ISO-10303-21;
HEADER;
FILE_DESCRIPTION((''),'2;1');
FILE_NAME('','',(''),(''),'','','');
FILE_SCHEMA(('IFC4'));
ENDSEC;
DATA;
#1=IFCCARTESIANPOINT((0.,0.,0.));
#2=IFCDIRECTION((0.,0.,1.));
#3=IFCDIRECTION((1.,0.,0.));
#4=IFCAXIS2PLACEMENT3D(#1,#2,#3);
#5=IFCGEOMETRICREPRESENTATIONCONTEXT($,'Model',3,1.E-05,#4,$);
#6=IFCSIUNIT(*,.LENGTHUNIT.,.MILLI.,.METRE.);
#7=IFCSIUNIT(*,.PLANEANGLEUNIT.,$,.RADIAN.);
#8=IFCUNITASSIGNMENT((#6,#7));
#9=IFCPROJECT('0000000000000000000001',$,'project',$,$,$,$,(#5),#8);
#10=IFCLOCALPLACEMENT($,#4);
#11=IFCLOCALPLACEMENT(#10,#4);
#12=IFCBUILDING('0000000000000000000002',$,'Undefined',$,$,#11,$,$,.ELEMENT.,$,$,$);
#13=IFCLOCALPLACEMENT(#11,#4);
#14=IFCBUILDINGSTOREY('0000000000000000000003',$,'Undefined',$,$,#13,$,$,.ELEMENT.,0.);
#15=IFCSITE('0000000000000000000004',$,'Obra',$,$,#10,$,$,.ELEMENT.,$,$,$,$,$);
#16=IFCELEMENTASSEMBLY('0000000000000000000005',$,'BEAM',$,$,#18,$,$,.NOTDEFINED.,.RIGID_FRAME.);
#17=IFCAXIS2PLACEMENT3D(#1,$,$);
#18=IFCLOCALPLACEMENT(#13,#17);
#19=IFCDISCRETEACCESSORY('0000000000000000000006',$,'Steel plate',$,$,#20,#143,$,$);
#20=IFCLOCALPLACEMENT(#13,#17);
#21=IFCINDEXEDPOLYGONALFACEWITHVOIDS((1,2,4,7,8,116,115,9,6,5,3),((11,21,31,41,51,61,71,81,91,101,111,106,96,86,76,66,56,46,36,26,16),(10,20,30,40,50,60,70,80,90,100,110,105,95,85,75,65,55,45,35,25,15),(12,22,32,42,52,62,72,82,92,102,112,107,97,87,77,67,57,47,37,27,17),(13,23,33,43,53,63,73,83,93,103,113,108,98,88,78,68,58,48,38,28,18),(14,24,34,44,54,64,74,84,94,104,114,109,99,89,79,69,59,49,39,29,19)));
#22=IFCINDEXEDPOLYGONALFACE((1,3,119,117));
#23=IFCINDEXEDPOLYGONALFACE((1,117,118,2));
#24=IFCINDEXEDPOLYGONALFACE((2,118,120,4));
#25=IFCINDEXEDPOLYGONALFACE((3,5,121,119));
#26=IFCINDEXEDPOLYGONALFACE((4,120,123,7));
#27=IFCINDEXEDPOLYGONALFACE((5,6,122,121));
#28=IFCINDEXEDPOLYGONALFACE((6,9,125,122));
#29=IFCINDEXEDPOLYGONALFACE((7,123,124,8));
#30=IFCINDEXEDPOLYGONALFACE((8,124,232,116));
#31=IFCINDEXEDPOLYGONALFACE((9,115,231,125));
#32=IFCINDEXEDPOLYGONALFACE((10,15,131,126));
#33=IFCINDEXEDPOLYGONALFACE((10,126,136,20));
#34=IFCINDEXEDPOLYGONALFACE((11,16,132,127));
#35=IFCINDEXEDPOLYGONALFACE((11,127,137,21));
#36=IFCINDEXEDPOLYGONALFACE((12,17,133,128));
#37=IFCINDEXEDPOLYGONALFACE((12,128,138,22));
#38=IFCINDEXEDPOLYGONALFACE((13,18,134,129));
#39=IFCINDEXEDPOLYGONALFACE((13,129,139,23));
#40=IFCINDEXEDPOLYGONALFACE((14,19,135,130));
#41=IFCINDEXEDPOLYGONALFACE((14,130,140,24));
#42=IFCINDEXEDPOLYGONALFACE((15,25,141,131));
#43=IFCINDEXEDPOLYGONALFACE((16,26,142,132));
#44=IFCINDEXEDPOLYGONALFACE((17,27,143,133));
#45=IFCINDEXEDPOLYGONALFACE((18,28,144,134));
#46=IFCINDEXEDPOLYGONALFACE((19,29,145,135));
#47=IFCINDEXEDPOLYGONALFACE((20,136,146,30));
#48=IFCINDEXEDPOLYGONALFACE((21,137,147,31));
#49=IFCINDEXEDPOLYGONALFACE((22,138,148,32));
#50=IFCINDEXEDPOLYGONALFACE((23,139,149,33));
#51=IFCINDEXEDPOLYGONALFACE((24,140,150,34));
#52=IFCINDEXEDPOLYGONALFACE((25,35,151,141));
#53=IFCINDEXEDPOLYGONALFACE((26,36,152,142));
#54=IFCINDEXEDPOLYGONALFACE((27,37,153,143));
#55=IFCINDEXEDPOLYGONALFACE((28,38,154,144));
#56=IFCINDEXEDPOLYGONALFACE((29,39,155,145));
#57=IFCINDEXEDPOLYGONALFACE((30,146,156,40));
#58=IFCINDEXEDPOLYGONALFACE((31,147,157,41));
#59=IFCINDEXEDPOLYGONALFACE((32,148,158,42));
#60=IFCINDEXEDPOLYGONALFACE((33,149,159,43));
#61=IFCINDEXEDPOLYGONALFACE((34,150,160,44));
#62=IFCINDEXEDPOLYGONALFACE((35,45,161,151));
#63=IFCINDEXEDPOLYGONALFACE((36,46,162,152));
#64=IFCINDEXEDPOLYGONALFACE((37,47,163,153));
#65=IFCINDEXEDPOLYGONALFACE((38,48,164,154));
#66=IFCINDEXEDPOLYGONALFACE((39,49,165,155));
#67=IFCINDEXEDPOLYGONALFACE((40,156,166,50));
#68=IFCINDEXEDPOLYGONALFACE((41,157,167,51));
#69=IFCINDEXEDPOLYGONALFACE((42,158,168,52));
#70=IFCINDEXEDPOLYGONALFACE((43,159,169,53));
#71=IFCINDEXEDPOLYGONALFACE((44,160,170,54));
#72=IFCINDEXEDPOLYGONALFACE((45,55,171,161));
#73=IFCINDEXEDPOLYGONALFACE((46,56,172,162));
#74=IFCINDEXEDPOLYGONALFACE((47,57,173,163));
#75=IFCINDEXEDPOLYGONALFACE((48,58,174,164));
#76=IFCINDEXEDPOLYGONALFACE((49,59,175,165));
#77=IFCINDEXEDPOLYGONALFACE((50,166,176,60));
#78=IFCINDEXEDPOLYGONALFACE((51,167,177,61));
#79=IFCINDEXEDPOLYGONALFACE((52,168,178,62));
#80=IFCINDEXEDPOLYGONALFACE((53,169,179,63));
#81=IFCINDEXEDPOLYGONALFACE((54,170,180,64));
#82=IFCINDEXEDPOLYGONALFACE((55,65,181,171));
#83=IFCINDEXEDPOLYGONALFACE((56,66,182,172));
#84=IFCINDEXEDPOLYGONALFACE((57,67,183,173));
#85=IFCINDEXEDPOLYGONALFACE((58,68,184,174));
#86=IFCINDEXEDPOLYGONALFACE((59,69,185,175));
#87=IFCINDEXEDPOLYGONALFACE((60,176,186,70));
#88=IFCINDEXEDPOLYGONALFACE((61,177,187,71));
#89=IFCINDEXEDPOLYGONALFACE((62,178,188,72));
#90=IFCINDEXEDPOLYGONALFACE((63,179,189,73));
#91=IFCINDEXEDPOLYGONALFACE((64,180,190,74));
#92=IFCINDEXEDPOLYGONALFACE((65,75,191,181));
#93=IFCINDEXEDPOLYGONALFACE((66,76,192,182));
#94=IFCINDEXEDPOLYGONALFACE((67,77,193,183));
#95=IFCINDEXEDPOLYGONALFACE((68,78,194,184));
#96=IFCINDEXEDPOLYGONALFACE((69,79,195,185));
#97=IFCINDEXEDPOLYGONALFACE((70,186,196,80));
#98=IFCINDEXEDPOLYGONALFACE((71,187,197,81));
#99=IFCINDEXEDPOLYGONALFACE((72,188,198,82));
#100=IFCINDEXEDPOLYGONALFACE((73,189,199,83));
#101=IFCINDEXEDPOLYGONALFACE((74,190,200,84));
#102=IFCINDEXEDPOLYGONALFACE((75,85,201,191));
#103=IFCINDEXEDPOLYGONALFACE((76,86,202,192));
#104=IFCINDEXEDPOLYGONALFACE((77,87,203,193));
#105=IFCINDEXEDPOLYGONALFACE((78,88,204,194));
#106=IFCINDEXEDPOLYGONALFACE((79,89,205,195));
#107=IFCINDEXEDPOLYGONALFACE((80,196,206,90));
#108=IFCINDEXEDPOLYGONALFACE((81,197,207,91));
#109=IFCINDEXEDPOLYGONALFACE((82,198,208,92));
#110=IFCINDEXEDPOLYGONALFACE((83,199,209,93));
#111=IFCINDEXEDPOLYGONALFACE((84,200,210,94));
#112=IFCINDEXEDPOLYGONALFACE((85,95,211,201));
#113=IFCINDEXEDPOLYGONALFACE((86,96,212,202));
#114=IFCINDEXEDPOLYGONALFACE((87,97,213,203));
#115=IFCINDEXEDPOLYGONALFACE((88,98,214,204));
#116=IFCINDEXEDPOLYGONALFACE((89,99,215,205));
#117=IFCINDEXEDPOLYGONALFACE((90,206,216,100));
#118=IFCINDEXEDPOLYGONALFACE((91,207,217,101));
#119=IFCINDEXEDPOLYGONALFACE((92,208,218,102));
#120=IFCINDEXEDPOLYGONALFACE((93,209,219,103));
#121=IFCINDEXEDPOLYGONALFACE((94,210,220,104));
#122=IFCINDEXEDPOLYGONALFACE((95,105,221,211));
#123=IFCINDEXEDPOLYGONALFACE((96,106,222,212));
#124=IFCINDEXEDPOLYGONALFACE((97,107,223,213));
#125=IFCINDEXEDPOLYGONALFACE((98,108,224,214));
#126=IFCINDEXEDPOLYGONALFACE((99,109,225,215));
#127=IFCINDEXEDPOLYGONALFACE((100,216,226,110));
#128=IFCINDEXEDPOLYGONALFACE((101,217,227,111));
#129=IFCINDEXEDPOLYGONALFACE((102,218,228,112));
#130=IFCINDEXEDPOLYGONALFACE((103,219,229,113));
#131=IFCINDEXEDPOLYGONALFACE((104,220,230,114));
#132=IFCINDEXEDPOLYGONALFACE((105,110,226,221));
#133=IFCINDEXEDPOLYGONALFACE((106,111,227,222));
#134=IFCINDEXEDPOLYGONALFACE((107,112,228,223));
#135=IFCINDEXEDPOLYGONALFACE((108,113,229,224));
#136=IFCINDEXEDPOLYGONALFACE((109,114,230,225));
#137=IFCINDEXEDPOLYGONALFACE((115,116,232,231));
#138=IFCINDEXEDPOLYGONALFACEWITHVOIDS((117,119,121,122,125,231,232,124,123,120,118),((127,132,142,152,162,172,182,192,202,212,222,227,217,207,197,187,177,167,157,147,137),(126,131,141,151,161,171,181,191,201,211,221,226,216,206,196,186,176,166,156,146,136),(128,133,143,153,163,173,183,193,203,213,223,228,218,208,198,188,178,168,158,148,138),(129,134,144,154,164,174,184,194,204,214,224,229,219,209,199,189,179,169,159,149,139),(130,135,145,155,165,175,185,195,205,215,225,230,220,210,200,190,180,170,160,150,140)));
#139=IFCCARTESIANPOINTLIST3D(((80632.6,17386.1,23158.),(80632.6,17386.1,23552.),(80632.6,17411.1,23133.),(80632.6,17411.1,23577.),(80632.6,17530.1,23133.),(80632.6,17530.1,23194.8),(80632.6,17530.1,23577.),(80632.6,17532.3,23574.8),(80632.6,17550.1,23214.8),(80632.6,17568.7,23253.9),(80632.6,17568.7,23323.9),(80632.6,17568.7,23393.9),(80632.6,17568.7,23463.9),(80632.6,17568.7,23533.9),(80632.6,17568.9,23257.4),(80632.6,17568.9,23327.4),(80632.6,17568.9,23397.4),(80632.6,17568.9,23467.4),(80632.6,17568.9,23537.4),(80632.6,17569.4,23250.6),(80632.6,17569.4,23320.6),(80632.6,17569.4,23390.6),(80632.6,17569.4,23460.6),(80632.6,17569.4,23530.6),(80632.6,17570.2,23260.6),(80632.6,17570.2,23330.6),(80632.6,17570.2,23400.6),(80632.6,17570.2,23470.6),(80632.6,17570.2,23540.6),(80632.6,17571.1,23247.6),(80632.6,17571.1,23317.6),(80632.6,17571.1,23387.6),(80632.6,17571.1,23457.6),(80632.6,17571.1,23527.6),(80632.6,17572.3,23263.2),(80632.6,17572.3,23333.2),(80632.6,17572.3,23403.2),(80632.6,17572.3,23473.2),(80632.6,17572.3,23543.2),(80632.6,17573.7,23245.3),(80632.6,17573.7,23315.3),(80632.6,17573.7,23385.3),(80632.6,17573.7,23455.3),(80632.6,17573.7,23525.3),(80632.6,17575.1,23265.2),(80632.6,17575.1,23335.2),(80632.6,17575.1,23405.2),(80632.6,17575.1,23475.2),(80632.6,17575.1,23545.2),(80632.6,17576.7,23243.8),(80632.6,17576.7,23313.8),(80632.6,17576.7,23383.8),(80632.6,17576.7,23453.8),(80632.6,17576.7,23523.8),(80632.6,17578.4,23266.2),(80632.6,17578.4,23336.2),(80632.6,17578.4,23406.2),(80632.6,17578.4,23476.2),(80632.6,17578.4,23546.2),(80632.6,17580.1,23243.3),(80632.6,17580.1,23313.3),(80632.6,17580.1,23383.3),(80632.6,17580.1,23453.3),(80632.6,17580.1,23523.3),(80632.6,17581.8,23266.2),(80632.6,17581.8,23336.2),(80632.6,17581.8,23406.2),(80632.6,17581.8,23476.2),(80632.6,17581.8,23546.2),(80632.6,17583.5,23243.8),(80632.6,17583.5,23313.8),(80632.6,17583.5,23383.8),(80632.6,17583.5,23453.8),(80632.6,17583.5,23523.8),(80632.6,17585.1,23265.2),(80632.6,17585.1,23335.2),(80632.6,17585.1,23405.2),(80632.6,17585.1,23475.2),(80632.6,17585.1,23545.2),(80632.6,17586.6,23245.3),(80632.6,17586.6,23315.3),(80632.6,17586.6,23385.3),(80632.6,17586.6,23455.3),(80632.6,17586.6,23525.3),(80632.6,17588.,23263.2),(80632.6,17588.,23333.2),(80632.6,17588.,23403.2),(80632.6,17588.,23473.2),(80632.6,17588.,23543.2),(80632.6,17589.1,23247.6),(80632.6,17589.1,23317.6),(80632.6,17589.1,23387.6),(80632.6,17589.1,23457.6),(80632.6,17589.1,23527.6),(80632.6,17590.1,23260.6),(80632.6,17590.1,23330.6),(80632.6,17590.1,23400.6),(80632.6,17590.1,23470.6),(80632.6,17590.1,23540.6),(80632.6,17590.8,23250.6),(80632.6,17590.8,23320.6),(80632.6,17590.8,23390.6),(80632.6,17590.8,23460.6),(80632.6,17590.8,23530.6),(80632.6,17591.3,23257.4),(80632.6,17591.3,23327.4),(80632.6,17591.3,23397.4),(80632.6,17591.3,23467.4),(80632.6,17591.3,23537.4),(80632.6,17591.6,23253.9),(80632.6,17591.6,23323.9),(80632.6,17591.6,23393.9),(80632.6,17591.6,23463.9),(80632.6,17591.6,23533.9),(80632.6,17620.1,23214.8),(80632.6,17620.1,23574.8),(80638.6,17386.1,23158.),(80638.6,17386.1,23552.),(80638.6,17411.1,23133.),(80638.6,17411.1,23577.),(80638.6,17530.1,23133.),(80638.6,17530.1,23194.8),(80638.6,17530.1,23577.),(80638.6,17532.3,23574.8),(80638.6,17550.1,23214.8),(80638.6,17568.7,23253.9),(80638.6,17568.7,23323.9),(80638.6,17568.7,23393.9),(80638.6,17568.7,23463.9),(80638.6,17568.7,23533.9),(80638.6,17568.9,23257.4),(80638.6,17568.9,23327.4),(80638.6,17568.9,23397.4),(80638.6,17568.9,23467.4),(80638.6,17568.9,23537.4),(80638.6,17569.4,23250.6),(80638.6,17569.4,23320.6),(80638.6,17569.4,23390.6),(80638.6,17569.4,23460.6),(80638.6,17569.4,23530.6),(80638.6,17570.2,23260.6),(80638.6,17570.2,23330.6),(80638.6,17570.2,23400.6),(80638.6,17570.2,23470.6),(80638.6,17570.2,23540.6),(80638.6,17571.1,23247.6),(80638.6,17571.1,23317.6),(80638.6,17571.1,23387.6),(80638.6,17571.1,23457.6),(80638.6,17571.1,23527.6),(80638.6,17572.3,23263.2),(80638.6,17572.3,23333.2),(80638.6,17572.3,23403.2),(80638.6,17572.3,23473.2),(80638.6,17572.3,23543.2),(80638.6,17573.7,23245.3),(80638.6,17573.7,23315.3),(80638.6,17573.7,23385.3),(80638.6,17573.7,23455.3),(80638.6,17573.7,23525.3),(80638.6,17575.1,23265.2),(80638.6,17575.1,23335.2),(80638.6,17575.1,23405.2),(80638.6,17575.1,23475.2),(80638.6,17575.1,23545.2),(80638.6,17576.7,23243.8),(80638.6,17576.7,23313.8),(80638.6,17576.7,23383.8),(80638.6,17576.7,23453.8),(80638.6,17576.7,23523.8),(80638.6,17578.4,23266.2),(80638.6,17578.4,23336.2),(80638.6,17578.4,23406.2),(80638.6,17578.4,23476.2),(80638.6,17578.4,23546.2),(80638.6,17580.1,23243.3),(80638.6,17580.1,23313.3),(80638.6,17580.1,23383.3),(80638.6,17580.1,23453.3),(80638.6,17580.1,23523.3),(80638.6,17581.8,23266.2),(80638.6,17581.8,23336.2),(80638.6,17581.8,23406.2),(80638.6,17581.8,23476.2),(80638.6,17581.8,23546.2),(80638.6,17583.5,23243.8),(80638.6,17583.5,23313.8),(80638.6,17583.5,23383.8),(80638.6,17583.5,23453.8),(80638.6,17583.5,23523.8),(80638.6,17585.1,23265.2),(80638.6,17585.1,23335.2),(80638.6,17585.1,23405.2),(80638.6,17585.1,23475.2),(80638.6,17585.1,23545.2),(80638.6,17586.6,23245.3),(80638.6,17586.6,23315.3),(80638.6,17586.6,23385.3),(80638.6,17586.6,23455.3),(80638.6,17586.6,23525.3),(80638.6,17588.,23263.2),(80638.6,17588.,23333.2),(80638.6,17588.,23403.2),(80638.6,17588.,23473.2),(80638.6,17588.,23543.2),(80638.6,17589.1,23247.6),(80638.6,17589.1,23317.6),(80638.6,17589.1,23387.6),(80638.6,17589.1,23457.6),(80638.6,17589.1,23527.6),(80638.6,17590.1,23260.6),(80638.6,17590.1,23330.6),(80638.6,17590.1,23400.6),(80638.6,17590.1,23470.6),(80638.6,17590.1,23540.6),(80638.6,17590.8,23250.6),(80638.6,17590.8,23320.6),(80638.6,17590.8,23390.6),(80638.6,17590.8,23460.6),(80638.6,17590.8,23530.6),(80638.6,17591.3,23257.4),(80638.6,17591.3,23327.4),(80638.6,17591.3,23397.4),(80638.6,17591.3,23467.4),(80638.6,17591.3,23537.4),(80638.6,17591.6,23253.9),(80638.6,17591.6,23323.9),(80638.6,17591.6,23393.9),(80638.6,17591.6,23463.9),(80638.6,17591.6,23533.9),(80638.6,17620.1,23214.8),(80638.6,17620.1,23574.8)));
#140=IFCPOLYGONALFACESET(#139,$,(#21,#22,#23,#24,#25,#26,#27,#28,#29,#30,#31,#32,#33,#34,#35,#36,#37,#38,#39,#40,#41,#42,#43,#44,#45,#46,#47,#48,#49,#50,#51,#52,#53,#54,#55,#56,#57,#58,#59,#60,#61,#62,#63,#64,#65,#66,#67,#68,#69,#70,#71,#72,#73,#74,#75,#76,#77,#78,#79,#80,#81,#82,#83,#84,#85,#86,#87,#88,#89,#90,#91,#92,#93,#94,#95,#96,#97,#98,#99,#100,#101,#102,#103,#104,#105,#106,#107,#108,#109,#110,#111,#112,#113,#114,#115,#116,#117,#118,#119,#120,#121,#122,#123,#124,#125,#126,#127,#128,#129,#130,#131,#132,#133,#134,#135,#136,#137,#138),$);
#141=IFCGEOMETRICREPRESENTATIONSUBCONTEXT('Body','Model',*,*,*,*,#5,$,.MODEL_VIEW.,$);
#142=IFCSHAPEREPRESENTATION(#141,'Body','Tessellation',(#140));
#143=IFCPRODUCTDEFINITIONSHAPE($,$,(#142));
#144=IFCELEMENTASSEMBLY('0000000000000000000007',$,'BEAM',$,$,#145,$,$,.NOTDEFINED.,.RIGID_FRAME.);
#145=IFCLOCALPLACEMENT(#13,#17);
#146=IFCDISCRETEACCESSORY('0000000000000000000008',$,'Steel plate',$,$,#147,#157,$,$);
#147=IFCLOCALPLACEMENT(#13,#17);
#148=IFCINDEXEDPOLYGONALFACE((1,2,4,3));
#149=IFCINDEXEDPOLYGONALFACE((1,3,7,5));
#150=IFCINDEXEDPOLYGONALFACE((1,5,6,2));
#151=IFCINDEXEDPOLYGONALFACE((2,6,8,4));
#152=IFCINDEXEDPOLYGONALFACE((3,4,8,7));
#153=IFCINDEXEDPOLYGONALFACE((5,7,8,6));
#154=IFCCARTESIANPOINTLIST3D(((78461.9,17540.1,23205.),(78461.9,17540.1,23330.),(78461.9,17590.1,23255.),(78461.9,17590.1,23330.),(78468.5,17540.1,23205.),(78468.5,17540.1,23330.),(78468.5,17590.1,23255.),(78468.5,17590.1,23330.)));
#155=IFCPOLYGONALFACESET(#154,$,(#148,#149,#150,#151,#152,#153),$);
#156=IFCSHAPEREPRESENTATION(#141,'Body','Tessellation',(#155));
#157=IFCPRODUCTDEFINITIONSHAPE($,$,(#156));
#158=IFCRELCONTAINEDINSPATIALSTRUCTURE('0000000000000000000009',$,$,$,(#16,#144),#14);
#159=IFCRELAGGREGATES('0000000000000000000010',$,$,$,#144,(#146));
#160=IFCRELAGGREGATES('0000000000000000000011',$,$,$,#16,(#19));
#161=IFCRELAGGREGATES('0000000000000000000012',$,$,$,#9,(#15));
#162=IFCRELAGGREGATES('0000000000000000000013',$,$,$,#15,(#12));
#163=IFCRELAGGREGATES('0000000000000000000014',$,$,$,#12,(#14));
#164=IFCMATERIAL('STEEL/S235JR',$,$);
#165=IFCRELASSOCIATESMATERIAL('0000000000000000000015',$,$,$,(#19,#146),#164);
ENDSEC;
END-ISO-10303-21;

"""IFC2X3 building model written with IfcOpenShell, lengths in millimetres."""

from ifc_helpers import new_model, si_unit, frame, origin_with_axes, origin_2d_with_axis, place, context, subcontext, project, spatial, polyline, circle, outline, extrude, source, transform, mapped, material, element, aggregate, save


model = new_model("IFC2X3")

# Units and contexts
model_context = context("Model", 3, precision=1e-05, world=origin_with_axes())
body_context = subcontext(model_context, "Body", "Model", "MODEL_VIEW")
ifc_project = project(units=[si_unit("LENGTHUNIT", "METRE", prefix="MILLI"), si_unit("PLANEANGLEUNIT", "RADIAN")], contexts=[model_context])

# Site, building, storey
site_placement = place(None, origin_with_axes())
site = spatial("IfcSite", under=ifc_project, at=site_placement, Name="Obra", CompositionType="ELEMENT")
building_placement = place(site_placement, origin_with_axes())
building = spatial("IfcBuilding", under=site, at=building_placement, Name="Undefined", CompositionType="ELEMENT")
storey_placement = place(building_placement, origin_with_axes())
storey = spatial("IfcBuildingStorey", under=building, at=storey_placement, Name="Undefined", CompositionType="ELEMENT", Elevation=0.0)

# Element assembly, discrete accessory, opening
assembly_1_placement = place(storey_placement, origin_with_axes())
assembly_1 = element("IfcElementAssembly", 1, at=assembly_1_placement, inside=storey, Name="BEAM", AssemblyPlace="NOTDEFINED", PredefinedType="RIGID_FRAME")
ifc_material_1 = material(Name="STEEL/S235JR")
discrete_accessory_1_placement = place(assembly_1_placement, frame((80635.6, 17386.1, 23158.0), z_axis=(1.0, 0.0, 0.0), x_axis=(0.0, 0.707107, -0.707107)))
discrete_accessory_1 = element("IfcDiscreteAccessory", 2, at=discrete_accessory_1_placement, material=ifc_material_1, Name="Steel plate", context=body_context, shape_type="SweptSolid", body=[
    extrude(outline(polyline([(0.0, 0.0), (35.4, 0.0), (119.5, 84.1), (75.8, 127.8), (75.8, 156.1), (125.3, 205.6), (-129.3, 460.2), (-191.3, 398.1), (-194.5, 398.1), (-194.5, 398.1), (-278.6, 314.0), (-278.6, 278.6), (0.0, 0.0)])), frame((0.0, 0.0, -3.0), z_axis=(0.0, 0.0, 1.0), x_axis=(1.0, 0.0, 0.0)), (0.0, 0.0, 1.0), 6.0),
])
shared_shape_1 = source(origin_with_axes(), body_context, "Body", "SweptSolid", [
    extrude(circle(Radius=11.5, at=origin_2d_with_axis()), frame((0.0, 3.2, 0.0), z_axis=(0.0, 1.0, 0.0), x_axis=(1.0, 0.0, 0.0)), (0.0, 0.0, 1.0), 6.2),
])
opening_1_placement = place(assembly_1_placement, frame((80641.9, 17540.1, 23574.8), z_axis=(0.0, 1.0, 0.0), x_axis=(0.0, 0.0, -1.0)))
element("IfcOpeningElement", 3, at=opening_1_placement, cuts=discrete_accessory_1, ObjectType="Opening", context=body_context, shape_type="MappedRepresentation", body=[
    mapped(shared_shape_1, transform((40.0, 0.0, 40.0))),
    mapped(shared_shape_1, transform((110.0, 0.0, 40.0))),
    mapped(shared_shape_1, transform((180.0, 0.0, 40.0))),
    mapped(shared_shape_1, transform((250.0, 0.0, 40.0))),
    mapped(shared_shape_1, transform((320.0, 0.0, 40.0))),
])

# Element assembly, discrete accessory
assembly_2_placement = place(storey_placement, origin_with_axes())
assembly_2 = element("IfcElementAssembly", 4, at=assembly_2_placement, inside=storey, Name="BEAM", AssemblyPlace="NOTDEFINED", PredefinedType="RIGID_FRAME")
discrete_accessory_2_placement = place(assembly_2_placement, frame((78465.2, 17540.1, 23330.0), z_axis=(1.0, 0.0, 0.0), x_axis=(0.0, 0.0, -1.0)))
discrete_accessory_2 = element("IfcDiscreteAccessory", 5, at=discrete_accessory_2_placement, material=ifc_material_1, Name="Steel plate", context=body_context, shape_type="SweptSolid", body=[
    extrude(outline(polyline([(0.0, 0.0), (150.0, 0.0), (150.0, -25.0), (75.0, 50.0), (0.0, 50.0), (0.0, 0.0)])), frame((0.0, 0.0, -3.3), z_axis=(0.0, 0.0, 1.0), x_axis=(1.0, 0.0, 0.0)), (0.0, 0.0, 1.0), 6.6),
])
aggregate(assembly_2, [discrete_accessory_2])

aggregate(assembly_1, [discrete_accessory_1])

save(model, "model.ifc")
